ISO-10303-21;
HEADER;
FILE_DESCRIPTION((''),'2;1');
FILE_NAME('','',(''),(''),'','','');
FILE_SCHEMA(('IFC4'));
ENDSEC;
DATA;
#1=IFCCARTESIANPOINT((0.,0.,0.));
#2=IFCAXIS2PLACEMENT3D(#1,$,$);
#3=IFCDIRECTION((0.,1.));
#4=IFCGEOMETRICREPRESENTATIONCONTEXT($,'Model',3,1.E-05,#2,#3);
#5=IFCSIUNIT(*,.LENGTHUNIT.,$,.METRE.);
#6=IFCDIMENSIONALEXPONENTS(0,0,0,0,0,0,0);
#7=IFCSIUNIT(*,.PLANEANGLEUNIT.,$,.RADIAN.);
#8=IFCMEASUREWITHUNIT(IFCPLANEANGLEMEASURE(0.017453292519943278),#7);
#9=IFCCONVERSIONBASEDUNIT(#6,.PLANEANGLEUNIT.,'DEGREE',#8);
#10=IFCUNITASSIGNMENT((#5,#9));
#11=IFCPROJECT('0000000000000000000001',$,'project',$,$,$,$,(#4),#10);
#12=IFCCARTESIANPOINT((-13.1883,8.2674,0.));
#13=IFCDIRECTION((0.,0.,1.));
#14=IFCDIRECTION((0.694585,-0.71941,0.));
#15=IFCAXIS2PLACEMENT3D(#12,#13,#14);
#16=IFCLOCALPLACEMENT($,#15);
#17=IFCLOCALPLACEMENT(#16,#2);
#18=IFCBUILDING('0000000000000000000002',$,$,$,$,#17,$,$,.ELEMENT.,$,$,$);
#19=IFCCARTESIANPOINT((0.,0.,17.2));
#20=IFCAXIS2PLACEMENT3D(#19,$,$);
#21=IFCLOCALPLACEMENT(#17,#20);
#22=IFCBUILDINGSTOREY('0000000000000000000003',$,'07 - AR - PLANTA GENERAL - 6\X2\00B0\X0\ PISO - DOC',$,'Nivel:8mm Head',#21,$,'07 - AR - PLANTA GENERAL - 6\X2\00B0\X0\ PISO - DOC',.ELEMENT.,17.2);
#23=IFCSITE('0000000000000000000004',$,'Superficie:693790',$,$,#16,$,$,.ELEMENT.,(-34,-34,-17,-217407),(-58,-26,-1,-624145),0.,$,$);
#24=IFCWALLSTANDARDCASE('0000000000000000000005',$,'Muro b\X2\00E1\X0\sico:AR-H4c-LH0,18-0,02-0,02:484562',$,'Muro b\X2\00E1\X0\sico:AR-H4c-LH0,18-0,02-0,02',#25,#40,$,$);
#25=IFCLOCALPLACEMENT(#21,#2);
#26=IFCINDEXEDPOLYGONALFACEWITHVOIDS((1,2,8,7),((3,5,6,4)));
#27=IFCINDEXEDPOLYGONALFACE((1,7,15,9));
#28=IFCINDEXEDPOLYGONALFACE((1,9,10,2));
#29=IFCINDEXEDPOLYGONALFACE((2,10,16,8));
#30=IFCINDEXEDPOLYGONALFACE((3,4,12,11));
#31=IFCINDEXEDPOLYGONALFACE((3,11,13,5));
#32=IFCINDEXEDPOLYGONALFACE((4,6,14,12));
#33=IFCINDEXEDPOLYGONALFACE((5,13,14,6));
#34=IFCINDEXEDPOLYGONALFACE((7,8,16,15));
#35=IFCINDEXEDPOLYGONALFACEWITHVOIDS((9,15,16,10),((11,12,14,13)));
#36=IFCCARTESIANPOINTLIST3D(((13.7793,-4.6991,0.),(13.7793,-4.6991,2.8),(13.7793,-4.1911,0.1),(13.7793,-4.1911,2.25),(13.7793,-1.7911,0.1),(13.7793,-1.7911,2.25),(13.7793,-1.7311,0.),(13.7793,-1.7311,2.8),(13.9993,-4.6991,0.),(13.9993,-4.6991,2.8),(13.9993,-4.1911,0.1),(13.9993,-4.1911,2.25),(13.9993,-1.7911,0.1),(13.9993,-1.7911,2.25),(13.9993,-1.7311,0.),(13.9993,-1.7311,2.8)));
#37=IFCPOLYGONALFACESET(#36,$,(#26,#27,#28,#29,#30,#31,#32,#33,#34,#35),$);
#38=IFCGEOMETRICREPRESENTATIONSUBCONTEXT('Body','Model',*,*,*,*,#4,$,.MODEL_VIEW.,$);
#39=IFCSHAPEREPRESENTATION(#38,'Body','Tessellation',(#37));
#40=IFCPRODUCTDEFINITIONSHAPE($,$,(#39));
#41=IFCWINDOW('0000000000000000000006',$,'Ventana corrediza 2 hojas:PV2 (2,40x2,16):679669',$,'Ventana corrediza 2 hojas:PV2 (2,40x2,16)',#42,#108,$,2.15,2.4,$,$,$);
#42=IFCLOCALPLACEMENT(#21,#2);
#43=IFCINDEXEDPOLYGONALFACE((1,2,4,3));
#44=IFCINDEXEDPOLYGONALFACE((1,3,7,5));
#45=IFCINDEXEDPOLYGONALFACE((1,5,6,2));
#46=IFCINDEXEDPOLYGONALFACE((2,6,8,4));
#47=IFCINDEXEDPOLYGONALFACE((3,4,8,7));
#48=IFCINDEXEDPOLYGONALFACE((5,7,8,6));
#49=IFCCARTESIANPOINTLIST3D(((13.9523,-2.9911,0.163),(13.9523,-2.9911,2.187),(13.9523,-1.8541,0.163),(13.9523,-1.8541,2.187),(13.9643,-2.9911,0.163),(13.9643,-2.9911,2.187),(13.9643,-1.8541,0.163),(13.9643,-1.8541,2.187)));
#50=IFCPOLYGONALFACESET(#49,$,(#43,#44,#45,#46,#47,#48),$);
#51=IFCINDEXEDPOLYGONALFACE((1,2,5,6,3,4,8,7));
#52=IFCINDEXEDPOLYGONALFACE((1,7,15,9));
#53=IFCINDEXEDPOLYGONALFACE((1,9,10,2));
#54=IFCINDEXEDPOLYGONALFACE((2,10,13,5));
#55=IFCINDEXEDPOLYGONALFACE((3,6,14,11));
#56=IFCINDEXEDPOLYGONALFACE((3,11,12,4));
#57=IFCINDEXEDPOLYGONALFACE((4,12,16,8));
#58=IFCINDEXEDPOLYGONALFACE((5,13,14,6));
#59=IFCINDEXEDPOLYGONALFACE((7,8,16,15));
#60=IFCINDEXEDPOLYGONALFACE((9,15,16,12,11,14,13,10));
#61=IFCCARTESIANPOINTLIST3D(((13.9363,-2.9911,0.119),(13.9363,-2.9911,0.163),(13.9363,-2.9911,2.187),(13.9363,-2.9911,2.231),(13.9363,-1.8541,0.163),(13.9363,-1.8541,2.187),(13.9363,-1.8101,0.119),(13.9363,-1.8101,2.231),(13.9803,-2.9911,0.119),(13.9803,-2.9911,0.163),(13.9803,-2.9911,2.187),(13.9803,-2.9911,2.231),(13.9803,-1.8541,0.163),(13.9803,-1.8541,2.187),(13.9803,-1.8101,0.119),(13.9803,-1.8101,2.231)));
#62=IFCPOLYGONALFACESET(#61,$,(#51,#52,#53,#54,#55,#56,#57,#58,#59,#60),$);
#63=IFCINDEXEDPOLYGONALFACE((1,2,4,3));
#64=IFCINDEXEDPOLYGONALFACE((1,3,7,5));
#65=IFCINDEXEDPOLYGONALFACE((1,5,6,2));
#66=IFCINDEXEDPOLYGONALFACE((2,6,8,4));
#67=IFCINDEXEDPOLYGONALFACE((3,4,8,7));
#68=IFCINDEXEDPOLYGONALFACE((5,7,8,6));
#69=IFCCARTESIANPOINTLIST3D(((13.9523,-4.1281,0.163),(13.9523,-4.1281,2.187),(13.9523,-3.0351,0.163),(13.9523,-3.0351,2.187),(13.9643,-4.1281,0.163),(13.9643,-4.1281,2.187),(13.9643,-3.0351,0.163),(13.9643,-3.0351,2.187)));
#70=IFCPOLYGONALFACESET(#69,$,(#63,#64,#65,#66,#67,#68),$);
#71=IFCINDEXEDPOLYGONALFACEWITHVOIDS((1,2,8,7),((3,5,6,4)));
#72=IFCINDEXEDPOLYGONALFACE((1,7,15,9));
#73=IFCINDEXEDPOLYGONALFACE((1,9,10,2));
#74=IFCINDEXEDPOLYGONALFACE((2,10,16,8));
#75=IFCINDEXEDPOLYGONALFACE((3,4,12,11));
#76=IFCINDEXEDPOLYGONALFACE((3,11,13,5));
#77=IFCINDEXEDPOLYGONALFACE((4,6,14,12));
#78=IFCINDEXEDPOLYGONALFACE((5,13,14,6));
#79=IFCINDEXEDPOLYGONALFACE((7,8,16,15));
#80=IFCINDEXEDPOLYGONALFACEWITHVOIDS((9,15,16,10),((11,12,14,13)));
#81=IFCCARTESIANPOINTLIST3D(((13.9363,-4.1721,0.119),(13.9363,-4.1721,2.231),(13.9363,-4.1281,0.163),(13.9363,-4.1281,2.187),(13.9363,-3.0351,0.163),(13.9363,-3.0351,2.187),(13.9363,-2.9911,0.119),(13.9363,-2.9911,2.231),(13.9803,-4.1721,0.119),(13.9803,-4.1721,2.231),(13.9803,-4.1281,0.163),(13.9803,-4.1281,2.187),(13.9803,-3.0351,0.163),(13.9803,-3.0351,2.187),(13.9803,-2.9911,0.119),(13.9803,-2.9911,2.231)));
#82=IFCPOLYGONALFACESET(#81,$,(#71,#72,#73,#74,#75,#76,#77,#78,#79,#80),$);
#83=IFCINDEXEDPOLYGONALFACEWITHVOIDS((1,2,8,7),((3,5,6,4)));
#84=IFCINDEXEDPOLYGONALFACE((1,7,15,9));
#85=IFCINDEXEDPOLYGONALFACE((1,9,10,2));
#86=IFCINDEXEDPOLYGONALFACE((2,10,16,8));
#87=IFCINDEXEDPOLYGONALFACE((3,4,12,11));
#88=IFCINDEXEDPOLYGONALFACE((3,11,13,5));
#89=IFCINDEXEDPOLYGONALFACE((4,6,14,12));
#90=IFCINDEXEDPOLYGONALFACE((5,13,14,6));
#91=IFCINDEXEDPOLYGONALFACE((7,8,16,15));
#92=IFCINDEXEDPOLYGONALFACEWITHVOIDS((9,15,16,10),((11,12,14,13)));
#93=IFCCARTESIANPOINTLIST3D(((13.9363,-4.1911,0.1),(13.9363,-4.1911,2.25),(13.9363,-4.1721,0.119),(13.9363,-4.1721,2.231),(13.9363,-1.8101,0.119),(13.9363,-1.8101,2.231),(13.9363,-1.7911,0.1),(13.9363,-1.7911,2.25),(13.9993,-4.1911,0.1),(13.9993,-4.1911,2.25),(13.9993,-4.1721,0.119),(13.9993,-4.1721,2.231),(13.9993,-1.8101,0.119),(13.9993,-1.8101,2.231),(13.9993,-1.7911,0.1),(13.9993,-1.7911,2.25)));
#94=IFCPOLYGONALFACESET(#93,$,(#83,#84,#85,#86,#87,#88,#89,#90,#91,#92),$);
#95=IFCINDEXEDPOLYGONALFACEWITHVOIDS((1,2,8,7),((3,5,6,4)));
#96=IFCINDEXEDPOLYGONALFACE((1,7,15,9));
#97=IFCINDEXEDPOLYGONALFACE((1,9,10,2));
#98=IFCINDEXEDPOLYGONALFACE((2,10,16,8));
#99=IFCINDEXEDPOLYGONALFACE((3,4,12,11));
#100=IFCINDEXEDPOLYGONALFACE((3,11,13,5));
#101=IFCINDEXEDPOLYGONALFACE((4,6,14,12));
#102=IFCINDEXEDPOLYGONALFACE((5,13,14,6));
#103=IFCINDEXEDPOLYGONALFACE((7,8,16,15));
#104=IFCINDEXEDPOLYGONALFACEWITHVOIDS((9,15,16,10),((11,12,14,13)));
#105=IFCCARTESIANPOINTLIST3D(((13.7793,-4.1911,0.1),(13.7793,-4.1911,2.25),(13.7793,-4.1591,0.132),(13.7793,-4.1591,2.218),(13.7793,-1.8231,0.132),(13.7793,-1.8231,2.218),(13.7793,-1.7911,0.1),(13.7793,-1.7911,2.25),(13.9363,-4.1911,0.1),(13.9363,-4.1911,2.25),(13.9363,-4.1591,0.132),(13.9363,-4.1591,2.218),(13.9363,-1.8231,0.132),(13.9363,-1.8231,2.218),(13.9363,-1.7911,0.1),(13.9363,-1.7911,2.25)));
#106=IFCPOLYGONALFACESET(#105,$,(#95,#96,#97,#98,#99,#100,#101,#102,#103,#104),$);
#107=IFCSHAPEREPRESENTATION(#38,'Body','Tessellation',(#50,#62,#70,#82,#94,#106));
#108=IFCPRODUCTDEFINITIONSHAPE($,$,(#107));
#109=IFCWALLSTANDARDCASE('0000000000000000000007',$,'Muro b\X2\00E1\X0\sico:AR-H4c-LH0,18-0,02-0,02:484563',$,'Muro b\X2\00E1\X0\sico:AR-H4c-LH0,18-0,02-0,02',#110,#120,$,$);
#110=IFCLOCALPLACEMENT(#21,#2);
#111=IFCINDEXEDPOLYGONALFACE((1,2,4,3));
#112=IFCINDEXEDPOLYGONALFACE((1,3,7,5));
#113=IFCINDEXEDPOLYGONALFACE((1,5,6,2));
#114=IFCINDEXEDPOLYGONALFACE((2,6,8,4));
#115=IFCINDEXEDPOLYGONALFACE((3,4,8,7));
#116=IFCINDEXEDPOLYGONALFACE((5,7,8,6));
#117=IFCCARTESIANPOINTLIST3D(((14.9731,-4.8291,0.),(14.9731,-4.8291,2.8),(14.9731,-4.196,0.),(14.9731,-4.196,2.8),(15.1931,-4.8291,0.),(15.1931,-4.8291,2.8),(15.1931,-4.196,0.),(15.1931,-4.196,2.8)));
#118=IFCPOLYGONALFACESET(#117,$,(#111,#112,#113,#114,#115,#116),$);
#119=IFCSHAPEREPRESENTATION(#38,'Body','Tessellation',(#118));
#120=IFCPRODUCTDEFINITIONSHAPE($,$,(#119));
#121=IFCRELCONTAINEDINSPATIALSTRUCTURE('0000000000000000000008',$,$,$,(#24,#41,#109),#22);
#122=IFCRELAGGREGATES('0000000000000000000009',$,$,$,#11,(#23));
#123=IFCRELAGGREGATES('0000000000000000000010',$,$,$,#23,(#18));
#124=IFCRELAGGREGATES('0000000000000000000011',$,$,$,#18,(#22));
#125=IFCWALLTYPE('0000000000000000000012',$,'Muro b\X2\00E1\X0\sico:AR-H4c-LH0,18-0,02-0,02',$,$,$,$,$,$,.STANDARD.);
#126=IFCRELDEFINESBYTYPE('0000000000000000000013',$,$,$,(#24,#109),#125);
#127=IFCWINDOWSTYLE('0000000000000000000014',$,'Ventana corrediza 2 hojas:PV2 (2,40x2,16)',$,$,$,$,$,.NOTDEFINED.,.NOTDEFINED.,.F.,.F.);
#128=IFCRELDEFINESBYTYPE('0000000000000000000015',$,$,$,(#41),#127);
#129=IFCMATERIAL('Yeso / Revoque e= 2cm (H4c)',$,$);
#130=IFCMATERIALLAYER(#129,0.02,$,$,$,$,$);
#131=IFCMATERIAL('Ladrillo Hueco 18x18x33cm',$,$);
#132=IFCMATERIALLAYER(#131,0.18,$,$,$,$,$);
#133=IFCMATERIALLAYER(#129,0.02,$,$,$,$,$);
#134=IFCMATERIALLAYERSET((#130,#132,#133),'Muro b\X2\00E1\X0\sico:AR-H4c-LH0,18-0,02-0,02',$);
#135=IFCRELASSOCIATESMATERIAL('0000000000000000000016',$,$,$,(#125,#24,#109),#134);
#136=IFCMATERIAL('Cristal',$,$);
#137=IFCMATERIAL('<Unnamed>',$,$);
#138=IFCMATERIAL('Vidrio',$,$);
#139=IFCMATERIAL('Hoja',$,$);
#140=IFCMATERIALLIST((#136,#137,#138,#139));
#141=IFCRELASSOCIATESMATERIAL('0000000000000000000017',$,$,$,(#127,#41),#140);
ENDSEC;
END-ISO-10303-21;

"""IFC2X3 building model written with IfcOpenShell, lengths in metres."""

from ifc_helpers import new_model, entity, si_unit, converted_unit, direction, frame, frame_2d, origin, place, context, subcontext, project, spatial, polyline, rectangle, outline, extrude, source, transform, mapped, material, material_list, layer, layer_set, layer_usage, type_object, type_shapes, element, fill, save


model = new_model("IFC2X3")

# Units and contexts
model_context = context("Model", 3, precision=1e-05, world=origin(), true_north=direction((0.0, 1.0)))
body_context = subcontext(model_context, "Body", "Model", "MODEL_VIEW")
ifc_project = project(units=[si_unit("LENGTHUNIT", "METRE"), converted_unit("PLANEANGLEUNIT", "DEGREE", entity("IfcPlaneAngleMeasure", 0.017453292519943278), si_unit("PLANEANGLEUNIT", "RADIAN"), dimensions=[0, 0, 0, 0, 0, 0, 0])], contexts=[model_context])

# Site, building, storey
site_placement = place(None, frame((-13.1883, 8.2674, 0.0), z_axis=(0.0, 0.0, 1.0), x_axis=(0.694585, -0.71941, 0.0)))
site = spatial("IfcSite", under=ifc_project, at=site_placement, Name="Superficie:693790", CompositionType="ELEMENT", RefLatitude=(-34, -34, -17, -217407), RefLongitude=(-58, -26, -1, -624145), RefElevation=0.0)
building_placement = place(site_placement, origin())
building = spatial("IfcBuilding", under=site, at=building_placement, CompositionType="ELEMENT")
storey_placement = place(building_placement, frame((0.0, 0.0, 17.2)))
storey = spatial("IfcBuildingStorey", under=building, at=storey_placement, Name="07 - AR - PLANTA GENERAL - 6° PISO - DOC", ObjectType="Nivel:8mm Head", LongName="07 - AR - PLANTA GENERAL - 6° PISO - DOC", CompositionType="ELEMENT", Elevation=17.2)

# Wall, opening, window
ifc_material_1 = material(Name="Yeso / Revoque e= 2cm (H4c)")
ifc_layer_1 = layer(ifc_material_1, 0.02)
ifc_material_2 = material(Name="Ladrillo Hueco 18x18x33cm")
ifc_layer_2 = layer(ifc_material_2, 0.18)
ifc_layer_3 = layer(ifc_material_1, 0.02)
ifc_layer_set_1 = layer_set([ifc_layer_1, ifc_layer_2, ifc_layer_3], Name="Muro básico:AR-H4c-LH0,18-0,02-0,02")
ifc_layer_usage_1 = layer_usage(ifc_layer_set_1, "AXIS2", "NEGATIVE", 0.11)
wall_type_1 = type_object("IfcWallType", Name="Muro básico:AR-H4c-LH0,18-0,02-0,02", PredefinedType="STANDARD", material=ifc_layer_set_1)
wall_1_placement = place(storey_placement, frame((13.8893, -4.6991, 0.0), z_axis=(0.0, 0.0, 1.0), x_axis=(0.0, 1.0, 0.0)))
wall_1 = element("IfcWallStandardCase", 1, at=wall_1_placement, inside=storey, type_object=wall_type_1, material=ifc_layer_usage_1, Name="Muro básico:AR-H4c-LH0,18-0,02-0,02:484562", ObjectType="Muro básico:AR-H4c-LH0,18-0,02-0,02", context=body_context, shape_type="SweptSolid", body=[
    extrude(rectangle(XDim=2.968, YDim=0.22, at=frame_2d((1.484, 0.0), x_axis=(-1.0, 0.0))), origin(), (0.0, 0.0, 1.0), 2.8),
])
opening_1_placement = place(wall_1_placement, frame((2.908, 0.11, 0.1)))
opening_1 = element("IfcOpeningElement", 2, at=opening_1_placement, cuts=wall_1, ObjectType="Opening", context=body_context, shape_type="SweptSolid", body=[
    extrude(rectangle(XDim=2.15, YDim=2.4, at=frame_2d((1.075, 1.2), x_axis=(1.0, 0.0))), frame((0.0, 0.0, 0.0), z_axis=(0.0, -1.0, 0.0), x_axis=(0.0, 0.0, 1.0)), (0.0, 0.0, 1.0), 0.22),
])
ifc_material_3 = material(Name="Cristal")
ifc_material_4 = material(Name="<Unnamed>")
ifc_material_5 = material(Name="Vidrio")
ifc_material_6 = material(Name="Hoja")
ifc_material_list = material_list([ifc_material_3, ifc_material_4, ifc_material_5, ifc_material_6])
window_style_1 = type_object("IfcWindowStyle", Name="Ventana corrediza 2 hojas:PV2 (2,40x2,16)", ConstructionType="NOTDEFINED", OperationType="NOTDEFINED", ParameterTakesPrecedence=False, Sizeable=False, material=ifc_material_list)
shared_shape_1 = source(origin(), body_context, "Body", "SweptSolid", [
    extrude(rectangle(XDim=0.012, YDim=1.137, at=frame_2d((0.0, 0.0), x_axis=(1.0, 0.0))), frame((0.6315, 0.179, 0.063), z_axis=(0.0, 0.0, 1.0), x_axis=(0.0, -1.0, 0.0)), (0.0, 0.0, 1.0), 2.024),
    extrude(outline(polyline([(-0.6015, -1.056), (0.5795, -1.056), (0.5795, -1.012), (-0.5575, -1.012), (-0.5575, 1.012), (0.5795, 1.012), (0.5795, 1.056), (-0.6015, 1.056), (-0.6015, -1.056)])), frame((0.6205, 0.157, 1.075), z_axis=(0.0, 1.0, 0.0), x_axis=(1.0, 0.0, 0.0)), (0.0, 0.0, 1.0), 0.044),
    extrude(rectangle(XDim=0.012, YDim=1.093, at=frame_2d((0.0, 0.0), x_axis=(1.0, 0.0))), frame((1.7905, 0.179, 0.063), z_axis=(0.0, 0.0, 1.0), x_axis=(0.0, -1.0, 0.0)), (0.0, 0.0, 1.0), 2.024),
    extrude(outline(polyline([(-0.5905, -1.056), (0.5905, -1.056), (0.5905, 1.056), (-0.5905, 1.056), (-0.5905, -1.056)]), holes=[polyline([(-0.5465, -1.012), (-0.5465, 1.012), (0.5465, 1.012), (0.5465, -1.012), (-0.5465, -1.012)])]), frame((1.7905, 0.157, 1.075), z_axis=(0.0, 1.0, 0.0), x_axis=(1.0, 0.0, 0.0)), (0.0, 0.0, 1.0), 0.044),
    extrude(outline(polyline([(-1.2, -1.075), (1.2, -1.075), (1.2, 1.075), (-1.2, 1.075), (-1.2, -1.075)]), holes=[polyline([(-1.181, -1.056), (-1.181, 1.056), (1.181, 1.056), (1.181, -1.056), (-1.181, -1.056)])]), frame((1.2, 0.157, 1.075), z_axis=(0.0, 1.0, 0.0), x_axis=(1.0, 0.0, 0.0)), (0.0, 0.0, 1.0), 0.063),
    extrude(outline(polyline([(-1.2, -1.075), (1.2, -1.075), (1.2, 1.075), (-1.2, 1.075), (-1.2, -1.075)]), holes=[polyline([(-1.168, -1.043), (-1.168, 1.043), (1.168, 1.043), (1.168, -1.043), (-1.168, -1.043)])]), frame((1.2, 0.0, 1.075), z_axis=(0.0, 1.0, 0.0), x_axis=(1.0, 0.0, 0.0)), (0.0, 0.0, 1.0), 0.157),
])
type_shapes(window_style_1, [shared_shape_1])
window_1_placement = place(opening_1_placement, frame((0.0, 0.0, 0.0), z_axis=(0.0, 0.0, 1.0), x_axis=(-1.0, 0.0, 0.0)))
window_1 = element("IfcWindow", 3, at=window_1_placement, inside=storey, type_object=window_style_1, material=ifc_material_list, Name="Ventana corrediza 2 hojas:PV2 (2,40x2,16):679669", ObjectType="Ventana corrediza 2 hojas:PV2 (2,40x2,16)", OverallHeight=2.15, OverallWidth=2.4, context=body_context, shape_type="MappedRepresentation", body=[
    mapped(shared_shape_1, transform((0.0, 0.0, 0.0), scale=1.0)),
])
fill(opening_1, window_1)

# Wall
ifc_layer_usage_2 = layer_usage(ifc_layer_set_1, "AXIS2", "NEGATIVE", 0.11)
wall_2_placement = place(storey_placement, frame((15.0831, -4.8291, 0.0), z_axis=(0.0, 0.0, 1.0), x_axis=(0.0, 1.0, 0.0)))
element("IfcWallStandardCase", 4, at=wall_2_placement, inside=storey, type_object=wall_type_1, material=ifc_layer_usage_2, Name="Muro básico:AR-H4c-LH0,18-0,02-0,02:484563", ObjectType="Muro básico:AR-H4c-LH0,18-0,02-0,02", context=body_context, shape_type="SweptSolid", body=[
    extrude(rectangle(XDim=0.6331, YDim=0.22, at=frame_2d((0.3166, 0.0), x_axis=(-1.0, 0.0))), origin(), (0.0, 0.0, 1.0), 2.8),
])

save(model, "model.ifc")
